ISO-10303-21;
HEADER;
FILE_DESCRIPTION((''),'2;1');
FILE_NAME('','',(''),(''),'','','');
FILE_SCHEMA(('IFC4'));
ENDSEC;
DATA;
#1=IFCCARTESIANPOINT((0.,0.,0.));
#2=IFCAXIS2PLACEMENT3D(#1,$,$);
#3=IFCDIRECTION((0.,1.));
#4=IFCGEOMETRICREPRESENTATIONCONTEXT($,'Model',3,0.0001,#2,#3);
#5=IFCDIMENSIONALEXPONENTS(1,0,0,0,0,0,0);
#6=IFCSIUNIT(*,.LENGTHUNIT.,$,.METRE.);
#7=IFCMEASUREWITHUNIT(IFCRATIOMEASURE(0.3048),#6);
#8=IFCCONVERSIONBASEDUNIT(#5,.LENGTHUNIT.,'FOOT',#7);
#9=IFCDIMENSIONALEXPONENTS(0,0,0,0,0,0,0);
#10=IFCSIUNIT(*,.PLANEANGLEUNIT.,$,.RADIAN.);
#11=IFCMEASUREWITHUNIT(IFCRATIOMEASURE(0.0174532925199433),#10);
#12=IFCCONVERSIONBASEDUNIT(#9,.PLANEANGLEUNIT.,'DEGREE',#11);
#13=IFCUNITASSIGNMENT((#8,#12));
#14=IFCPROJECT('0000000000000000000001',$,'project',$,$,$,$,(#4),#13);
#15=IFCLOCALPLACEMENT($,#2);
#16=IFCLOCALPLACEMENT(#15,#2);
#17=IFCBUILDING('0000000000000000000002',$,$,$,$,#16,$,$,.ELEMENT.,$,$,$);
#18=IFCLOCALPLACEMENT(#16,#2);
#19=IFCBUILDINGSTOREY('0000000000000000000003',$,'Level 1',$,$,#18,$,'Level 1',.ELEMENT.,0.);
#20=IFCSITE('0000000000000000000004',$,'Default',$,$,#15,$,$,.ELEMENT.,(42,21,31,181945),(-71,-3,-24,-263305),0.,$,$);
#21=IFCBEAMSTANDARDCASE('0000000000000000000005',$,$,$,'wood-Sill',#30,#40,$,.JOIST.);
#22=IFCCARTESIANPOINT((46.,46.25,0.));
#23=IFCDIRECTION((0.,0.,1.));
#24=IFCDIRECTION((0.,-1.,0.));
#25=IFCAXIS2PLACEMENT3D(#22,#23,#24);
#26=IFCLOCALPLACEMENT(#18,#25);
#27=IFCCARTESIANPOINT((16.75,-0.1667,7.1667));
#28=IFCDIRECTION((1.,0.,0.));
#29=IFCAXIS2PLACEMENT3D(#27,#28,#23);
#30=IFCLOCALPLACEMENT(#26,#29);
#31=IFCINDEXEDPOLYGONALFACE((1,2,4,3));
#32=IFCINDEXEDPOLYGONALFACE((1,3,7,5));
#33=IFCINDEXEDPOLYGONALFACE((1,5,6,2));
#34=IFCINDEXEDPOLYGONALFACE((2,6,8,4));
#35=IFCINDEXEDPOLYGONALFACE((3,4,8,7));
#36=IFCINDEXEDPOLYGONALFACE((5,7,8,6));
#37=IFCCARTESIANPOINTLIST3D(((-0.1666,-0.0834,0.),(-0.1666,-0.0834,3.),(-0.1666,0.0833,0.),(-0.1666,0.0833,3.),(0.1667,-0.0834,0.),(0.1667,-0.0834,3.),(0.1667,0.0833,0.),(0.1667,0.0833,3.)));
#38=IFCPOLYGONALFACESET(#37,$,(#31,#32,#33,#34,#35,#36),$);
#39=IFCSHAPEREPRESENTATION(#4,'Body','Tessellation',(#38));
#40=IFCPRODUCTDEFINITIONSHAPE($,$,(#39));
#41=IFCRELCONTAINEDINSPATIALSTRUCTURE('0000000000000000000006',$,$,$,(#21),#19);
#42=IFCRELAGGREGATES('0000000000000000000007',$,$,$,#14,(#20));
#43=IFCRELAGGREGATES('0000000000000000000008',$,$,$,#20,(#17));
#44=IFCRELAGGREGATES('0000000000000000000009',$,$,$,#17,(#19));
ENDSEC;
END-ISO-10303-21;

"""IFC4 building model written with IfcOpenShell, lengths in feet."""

from ifc_helpers import new_model, entity, si_unit, converted_unit, direction, frame, origin, origin_with_axes, place, context, project, spatial, rectangle, extrude, element, save


model = new_model("IFC4")

# Units and contexts
model_context = context("Model", 3, precision=0.0001, world=origin(), true_north=direction((0.0, 1.0)))
ifc_project = project(units=[converted_unit("LENGTHUNIT", "FOOT", entity("IfcRatioMeasure", 0.3048), si_unit("LENGTHUNIT", "METRE"), dimensions=[1, 0, 0, 0, 0, 0, 0]), converted_unit("PLANEANGLEUNIT", "DEGREE", entity("IfcRatioMeasure", 0.0174532925199433), si_unit("PLANEANGLEUNIT", "RADIAN"), dimensions=[0, 0, 0, 0, 0, 0, 0])], contexts=[model_context])

# Site, building, storey
site_placement = place(None, origin())
site = spatial("IfcSite", under=ifc_project, at=site_placement, Name="Default", CompositionType="ELEMENT", RefLatitude=(42, 21, 31, 181945), RefLongitude=(-71, -3, -24, -263305), RefElevation=0.0)
building_placement = place(site_placement, origin())
building = spatial("IfcBuilding", under=site, at=building_placement, CompositionType="ELEMENT")
storey_placement = place(building_placement, origin())
storey = spatial("IfcBuildingStorey", under=building, at=storey_placement, Name="Level 1", LongName="Level 1", CompositionType="ELEMENT", Elevation=0.0)

# Shared definitions
placement_1 = place(storey_placement, frame((46.0, 46.25, 0.0), z_axis=(0.0, 0.0, 1.0), x_axis=(0.0, -1.0, 0.0)))

# Beam
for number, where, z_axis, x_axis in (
    (1, (16.75, -0.1667, 7.1667), (1.0, 0.0, 0.0), (0.0, 0.0, 1.0)),
):
    element("IfcBeamStandardCase", number, at=place(placement_1, frame(where, z_axis=z_axis, x_axis=x_axis)), inside=storey, ObjectType="wood-Sill", PredefinedType="JOIST", context=model_context, shape_type="SweptSolid", body=[
        extrude(rectangle(XDim=0.3333, YDim=0.1667), origin_with_axes(), (0.0, 0.0, 1.0), 3.0),
    ])

save(model, "model.ifc")
